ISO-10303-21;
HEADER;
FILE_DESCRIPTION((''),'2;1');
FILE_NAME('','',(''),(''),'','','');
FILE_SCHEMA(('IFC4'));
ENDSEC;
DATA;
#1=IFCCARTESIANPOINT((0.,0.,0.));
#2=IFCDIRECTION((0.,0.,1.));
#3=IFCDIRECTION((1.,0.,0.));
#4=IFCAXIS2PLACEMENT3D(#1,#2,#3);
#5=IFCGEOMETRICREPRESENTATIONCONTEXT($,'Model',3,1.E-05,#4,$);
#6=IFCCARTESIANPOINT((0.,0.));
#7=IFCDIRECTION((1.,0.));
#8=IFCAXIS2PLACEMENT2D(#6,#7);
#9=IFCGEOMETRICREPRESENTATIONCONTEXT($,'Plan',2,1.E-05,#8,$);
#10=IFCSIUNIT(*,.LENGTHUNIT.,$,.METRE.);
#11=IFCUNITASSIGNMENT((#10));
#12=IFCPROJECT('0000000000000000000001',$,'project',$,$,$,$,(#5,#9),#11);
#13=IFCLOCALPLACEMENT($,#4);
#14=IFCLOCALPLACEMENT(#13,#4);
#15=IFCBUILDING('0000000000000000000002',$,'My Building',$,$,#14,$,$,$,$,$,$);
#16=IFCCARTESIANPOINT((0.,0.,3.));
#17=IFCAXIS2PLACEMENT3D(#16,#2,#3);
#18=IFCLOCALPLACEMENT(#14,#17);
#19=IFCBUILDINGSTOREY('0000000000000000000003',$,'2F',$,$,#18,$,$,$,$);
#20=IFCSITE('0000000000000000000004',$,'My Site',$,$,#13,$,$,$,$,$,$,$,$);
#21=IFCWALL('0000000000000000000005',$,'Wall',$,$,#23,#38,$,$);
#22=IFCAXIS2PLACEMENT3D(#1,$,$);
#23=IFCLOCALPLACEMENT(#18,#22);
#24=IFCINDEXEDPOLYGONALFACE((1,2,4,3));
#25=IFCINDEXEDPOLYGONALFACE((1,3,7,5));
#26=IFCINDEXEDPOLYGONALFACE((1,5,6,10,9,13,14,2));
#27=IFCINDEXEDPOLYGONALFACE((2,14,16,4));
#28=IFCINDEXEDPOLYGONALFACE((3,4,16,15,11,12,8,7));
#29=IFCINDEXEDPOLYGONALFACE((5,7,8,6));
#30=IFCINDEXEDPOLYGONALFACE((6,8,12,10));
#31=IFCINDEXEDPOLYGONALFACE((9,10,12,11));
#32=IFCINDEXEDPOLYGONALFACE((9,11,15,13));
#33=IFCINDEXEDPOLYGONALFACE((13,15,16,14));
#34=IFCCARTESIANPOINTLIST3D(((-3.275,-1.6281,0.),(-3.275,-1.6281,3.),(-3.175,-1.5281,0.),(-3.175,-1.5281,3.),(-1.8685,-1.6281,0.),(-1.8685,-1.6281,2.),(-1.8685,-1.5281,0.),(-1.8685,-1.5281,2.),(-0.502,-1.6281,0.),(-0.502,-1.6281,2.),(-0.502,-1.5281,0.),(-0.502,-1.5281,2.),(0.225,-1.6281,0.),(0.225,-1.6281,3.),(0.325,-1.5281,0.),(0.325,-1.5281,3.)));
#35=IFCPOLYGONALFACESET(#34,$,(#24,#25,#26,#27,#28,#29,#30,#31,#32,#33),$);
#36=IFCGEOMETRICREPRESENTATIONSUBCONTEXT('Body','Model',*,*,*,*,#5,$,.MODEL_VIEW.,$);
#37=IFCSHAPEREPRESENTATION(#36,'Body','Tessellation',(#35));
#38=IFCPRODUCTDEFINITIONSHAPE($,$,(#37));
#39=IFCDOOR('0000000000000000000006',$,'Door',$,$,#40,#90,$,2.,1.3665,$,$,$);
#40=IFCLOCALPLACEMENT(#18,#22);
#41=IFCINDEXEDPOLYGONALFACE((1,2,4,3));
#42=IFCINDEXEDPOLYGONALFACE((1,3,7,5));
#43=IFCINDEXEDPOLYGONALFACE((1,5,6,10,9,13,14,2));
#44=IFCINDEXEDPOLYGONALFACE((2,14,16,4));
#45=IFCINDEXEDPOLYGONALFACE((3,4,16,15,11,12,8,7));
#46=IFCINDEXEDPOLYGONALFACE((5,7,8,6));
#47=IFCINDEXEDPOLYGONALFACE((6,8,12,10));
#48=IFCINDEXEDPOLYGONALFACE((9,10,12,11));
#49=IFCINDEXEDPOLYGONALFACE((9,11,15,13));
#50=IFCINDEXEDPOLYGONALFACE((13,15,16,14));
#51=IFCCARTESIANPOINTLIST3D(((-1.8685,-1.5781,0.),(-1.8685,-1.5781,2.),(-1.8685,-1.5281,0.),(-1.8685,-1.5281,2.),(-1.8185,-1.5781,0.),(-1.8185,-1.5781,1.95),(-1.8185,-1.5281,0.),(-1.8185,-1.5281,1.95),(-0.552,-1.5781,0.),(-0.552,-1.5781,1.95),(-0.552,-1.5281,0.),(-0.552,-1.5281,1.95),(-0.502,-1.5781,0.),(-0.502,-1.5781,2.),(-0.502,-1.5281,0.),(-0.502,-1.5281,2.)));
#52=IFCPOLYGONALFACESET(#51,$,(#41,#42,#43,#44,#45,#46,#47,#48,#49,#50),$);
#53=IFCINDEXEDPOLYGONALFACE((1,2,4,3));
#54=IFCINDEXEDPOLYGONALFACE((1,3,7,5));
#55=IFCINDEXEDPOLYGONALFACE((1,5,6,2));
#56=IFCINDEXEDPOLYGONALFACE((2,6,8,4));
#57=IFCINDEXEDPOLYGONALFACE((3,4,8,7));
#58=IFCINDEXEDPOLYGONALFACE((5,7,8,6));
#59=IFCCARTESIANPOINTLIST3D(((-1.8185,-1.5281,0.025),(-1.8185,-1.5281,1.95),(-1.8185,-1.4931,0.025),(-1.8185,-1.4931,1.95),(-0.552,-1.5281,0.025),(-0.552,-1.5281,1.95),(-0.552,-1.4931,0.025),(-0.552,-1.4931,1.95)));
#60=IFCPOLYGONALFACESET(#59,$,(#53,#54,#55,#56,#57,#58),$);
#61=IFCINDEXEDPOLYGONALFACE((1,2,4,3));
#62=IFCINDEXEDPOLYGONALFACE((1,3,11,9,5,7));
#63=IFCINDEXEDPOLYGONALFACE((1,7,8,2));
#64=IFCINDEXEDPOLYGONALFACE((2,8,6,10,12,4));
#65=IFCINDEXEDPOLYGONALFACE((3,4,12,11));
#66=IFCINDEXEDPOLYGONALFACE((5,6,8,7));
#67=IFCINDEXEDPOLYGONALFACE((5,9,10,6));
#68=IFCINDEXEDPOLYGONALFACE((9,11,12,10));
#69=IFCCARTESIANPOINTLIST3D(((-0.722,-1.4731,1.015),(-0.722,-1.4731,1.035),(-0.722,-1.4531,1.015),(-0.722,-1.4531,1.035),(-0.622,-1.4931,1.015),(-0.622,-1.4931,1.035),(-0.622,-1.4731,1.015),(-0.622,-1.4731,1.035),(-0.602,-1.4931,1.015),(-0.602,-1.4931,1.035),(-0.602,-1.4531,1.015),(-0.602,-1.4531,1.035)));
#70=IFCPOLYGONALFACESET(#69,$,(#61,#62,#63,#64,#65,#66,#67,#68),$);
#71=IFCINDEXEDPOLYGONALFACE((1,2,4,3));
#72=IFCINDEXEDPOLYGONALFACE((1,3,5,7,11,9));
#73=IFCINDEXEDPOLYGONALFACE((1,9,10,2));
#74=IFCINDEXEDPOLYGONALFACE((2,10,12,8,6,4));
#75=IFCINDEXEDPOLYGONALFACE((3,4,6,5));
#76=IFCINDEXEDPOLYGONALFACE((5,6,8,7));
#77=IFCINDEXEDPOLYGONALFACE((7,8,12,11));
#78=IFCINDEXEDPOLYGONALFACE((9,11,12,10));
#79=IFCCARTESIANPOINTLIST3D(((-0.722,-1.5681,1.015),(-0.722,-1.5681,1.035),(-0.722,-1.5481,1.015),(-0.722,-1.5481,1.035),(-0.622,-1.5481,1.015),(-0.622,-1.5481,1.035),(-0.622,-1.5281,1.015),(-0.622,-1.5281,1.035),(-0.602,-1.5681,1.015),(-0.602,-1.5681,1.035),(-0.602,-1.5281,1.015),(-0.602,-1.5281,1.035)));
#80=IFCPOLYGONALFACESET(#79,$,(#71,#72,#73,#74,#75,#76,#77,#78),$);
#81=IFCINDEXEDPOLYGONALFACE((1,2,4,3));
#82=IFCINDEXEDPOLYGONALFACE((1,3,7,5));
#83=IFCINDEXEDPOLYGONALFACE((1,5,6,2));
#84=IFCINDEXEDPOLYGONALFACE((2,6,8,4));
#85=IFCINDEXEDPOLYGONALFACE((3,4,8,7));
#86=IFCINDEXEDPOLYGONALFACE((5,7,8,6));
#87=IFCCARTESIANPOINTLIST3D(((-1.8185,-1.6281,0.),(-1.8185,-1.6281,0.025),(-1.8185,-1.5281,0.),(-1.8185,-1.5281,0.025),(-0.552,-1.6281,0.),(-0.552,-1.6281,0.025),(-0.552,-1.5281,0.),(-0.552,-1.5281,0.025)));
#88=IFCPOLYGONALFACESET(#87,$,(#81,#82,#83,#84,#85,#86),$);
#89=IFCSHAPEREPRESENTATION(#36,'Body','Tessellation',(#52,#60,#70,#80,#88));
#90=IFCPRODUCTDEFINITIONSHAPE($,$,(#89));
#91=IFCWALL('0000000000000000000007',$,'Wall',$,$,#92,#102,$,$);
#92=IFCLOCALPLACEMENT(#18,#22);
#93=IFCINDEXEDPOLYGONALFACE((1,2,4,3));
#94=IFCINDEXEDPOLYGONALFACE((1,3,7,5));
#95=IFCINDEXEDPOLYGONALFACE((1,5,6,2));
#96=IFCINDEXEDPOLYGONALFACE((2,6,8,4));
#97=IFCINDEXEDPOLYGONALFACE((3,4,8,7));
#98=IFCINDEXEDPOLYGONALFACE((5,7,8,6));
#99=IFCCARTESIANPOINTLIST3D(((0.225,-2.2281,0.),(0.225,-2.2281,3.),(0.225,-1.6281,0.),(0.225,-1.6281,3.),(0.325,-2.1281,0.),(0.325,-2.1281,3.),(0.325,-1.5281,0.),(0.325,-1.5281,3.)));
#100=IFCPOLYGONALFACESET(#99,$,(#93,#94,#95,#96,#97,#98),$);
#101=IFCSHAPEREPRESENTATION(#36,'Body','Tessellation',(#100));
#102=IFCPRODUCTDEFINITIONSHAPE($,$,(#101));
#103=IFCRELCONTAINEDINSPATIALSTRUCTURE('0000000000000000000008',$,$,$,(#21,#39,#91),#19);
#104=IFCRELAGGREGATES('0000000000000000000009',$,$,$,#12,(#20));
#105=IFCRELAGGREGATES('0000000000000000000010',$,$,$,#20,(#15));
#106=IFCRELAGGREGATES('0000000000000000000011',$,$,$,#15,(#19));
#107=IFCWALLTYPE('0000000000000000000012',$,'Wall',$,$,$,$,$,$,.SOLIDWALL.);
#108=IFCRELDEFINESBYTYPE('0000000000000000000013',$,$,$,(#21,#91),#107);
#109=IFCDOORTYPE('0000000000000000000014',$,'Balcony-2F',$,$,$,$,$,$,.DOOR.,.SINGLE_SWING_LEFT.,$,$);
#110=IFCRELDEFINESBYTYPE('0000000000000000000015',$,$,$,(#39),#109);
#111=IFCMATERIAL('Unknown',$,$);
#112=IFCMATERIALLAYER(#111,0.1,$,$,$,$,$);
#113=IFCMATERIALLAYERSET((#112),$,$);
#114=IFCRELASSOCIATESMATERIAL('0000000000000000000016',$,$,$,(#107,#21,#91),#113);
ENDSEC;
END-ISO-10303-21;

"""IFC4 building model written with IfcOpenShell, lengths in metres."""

from ifc_helpers import new_model, entity, si_unit, frame, origin_with_axes, origin_2d_with_axis, place, context, subcontext, project, spatial, line, indexed_curve, outline, extrude, shape, source, transform, mapped, material, layer, layer_set, layer_usage, type_object, type_shapes, element, fill, save


model = new_model("IFC4")

# Units and contexts
model_context = context("Model", 3, precision=1e-05, world=origin_with_axes())
plan_context = context("Plan", 2, precision=1e-05, world=origin_2d_with_axis())
body_context_1 = subcontext(model_context, "Body", "Model", "MODEL_VIEW")
body_context_2 = subcontext(plan_context, "Body", "Plan", "PLAN_VIEW")
ifc_project = project(units=[si_unit("LENGTHUNIT", "METRE")], contexts=[model_context, plan_context])

# Site, building, storey
site_placement = place(None, origin_with_axes())
site = spatial("IfcSite", under=ifc_project, at=site_placement, Name="My Site")
building_placement = place(site_placement, origin_with_axes())
building = spatial("IfcBuilding", under=site, at=building_placement, Name="My Building")
storey_placement = place(building_placement, frame((0.0, 0.0, 3.0), z_axis=(0.0, 0.0, 1.0), x_axis=(1.0, 0.0, 0.0)))
storey = spatial("IfcBuildingStorey", under=building, at=storey_placement, Name="2F")

# Shared definitions
ifc_material = material(Name="Unknown")

# Wall, opening, door
ifc_layer_1 = layer(ifc_material, 0.1)
ifc_layer_set_1 = layer_set([ifc_layer_1])
ifc_layer_usage_1 = layer_usage(ifc_layer_set_1, "AXIS2", "POSITIVE", 0.0)
wall_type = type_object("IfcWallType", Name="Wall", PredefinedType="SOLIDWALL", material=ifc_layer_set_1)
wall_1_placement = place(storey_placement, frame((-3.275, -1.6281, 0.0), z_axis=(0.0, 0.0, 1.0), x_axis=(1.0, 0.0, 0.0)))
wall_1 = element("IfcWall", 1, at=wall_1_placement, inside=storey, type_object=wall_type, material=ifc_layer_usage_1, Name="Wall", context=body_context_1, shape_type="SweptSolid", body=[
    extrude(outline(indexed_curve([(0.0, 0.0), (0.1, 0.1), (3.6, 0.1), (3.5, 0.0)], segments=[line(1, 2, 3, 4, 1)])), origin_with_axes(), (0.0, 0.0, 1.0), 3.0),
])
shared_shape_1 = source(origin_with_axes(), body_context_1, "Body", "SweptSolid", [
    extrude(outline(indexed_curve([(0.0, 0.0), (1.3665, 0.0), (1.3665, 2.0), (0.0, 2.0)], segments=[line(1, 2, 3, 4, 1)])), frame((0.0, -0.6, 0.0), z_axis=(0.0, -1.0, 0.0), x_axis=(1.0, 0.0, 0.0)), (0.0, 0.0, -1.0), 1.2),
])
opening_1_placement = place(wall_1_placement, frame((2.773, 0.1, 0.0), z_axis=(0.0, 0.0, 1.0), x_axis=(-1.0, 0.0, 0.0)))
opening_1 = element("IfcOpeningElement", 2, at=opening_1_placement, cuts=wall_1, PredefinedType="OPENING", context=body_context_1, shape_type="MappedRepresentation", body=[
    mapped(shared_shape_1, transform((0.0, 0.0, 0.0), x_axis=(1.0, 0.0, 0.0), y_axis=(0.0, 1.0, 0.0), z_axis=(0.0, 0.0, 1.0), scale=1.0)),
])
door_type_1 = type_object("IfcDoorType", Name="Balcony-2F", OperationType="SINGLE_SWING_LEFT", PredefinedType="DOOR")
shared_shape_2 = source(origin_with_axes(), body_context_1, "Body", "SweptSolid", [
    extrude(outline(indexed_curve([(0.0, 0.0), (0.0, 2.0), (1.3665, 2.0), (1.3665, 0.0), (1.3165, 0.0), (1.3165, 1.95), (0.05, 1.95), (0.05, 0.0)], segments=[line(1, 2, 3, 4, 5, 6, 7, 8, 1)])), frame((0.0, 0.0, 0.0), z_axis=(0.0, -1.0, 0.0), x_axis=(1.0, 0.0, 0.0)), (0.0, 0.0, -1.0), 0.05),
    extrude(outline(indexed_curve([(0.0, 0.0), (1.2665, 0.0), (1.2665, 0.035), (0.0, 0.035)], segments=[line(1, 2, 3, 4, 1)])), frame((0.05, -0.035, 0.025), z_axis=(0.0, 0.0, 1.0), x_axis=(1.0, 0.0, 0.0)), (0.0, 0.0, 1.0), 1.925),
    extrude(outline(indexed_curve([(0.0, 0.0), (0.0, -0.04), (0.12, -0.04), (0.12, -0.02), (0.02, -0.02), (0.02, 0.0)], segments=[line(1, 2, 3, 4, 5, 6, 1)])), frame((0.1, -0.035, 1.015), z_axis=(0.0, 0.0, 1.0), x_axis=(1.0, 0.0, 0.0)), (0.0, 0.0, 1.0), 0.02),
    extrude(outline(indexed_curve([(0.0, 0.0), (0.0, 0.04), (0.12, 0.04), (0.12, 0.02), (0.02, 0.02), (0.02, 0.0)], segments=[line(1, 2, 3, 4, 5, 6, 1)])), frame((0.1, 0.0, 1.015), z_axis=(0.0, 0.0, 1.0), x_axis=(1.0, 0.0, 0.0)), (0.0, 0.0, 1.0), 0.02),
    extrude(outline(indexed_curve([(0.0, 0.0), (1.2665, 0.0), (1.2665, 0.1), (0.0, 0.1)], segments=[line(1, 2, 3, 4, 1)])), frame((0.05, 0.0, 0.0), z_axis=(0.0, 0.0, 1.0), x_axis=(1.0, 0.0, 0.0)), (0.0, 0.0, 1.0), 0.025),
])
shared_shape_3 = source(origin_with_axes(), body_context_2, "Body", "Curve2D", [
    entity("IfcIndexedPolyCurve", entity("IfcCartesianPointList2D", [[0.0, 0.0], [0.05, 0.0], [0.05, 0.05], [0.0, 0.05]]), [entity("IfcLineIndex", [1, 2, 3, 4, 1])]),
    entity("IfcIndexedPolyCurve", entity("IfcCartesianPointList2D", [[1.3665, 0.0], [1.3165, 0.0], [1.3165, 0.05], [1.3665, 0.05]]), [entity("IfcLineIndex", [1, 2, 3, 4, 1])]),
    entity("IfcIndexedPolyCurve", entity("IfcCartesianPointList2D", [[1.9498, -0.035], [0.6833, -0.035], [0.6833, 0.0], [1.9498, 0.0]]), [entity("IfcLineIndex", [1, 2, 3, 4, 1])]),
])
type_shapes(door_type_1, [shared_shape_2, shared_shape_3])
door_1_placement = place(opening_1_placement, origin_with_axes())
door_1 = element("IfcDoor", 3, at=door_1_placement, inside=storey, type_object=door_type_1, Name="Door", OverallHeight=2.0, OverallWidth=1.3665, shapes=[
    shape(body_context_1, "Body", "MappedRepresentation", [mapped(shared_shape_2, transform((0.0, 0.0, 0.0), x_axis=(1.0, 0.0, 0.0), y_axis=(0.0, 1.0, 0.0), z_axis=(0.0, 0.0, 1.0), scale=1.0))]),
    shape(body_context_2, "Body", "MappedRepresentation", [mapped(shared_shape_3, transform((0.0, 0.0, 0.0), x_axis=(1.0, 0.0, 0.0), y_axis=(0.0, 1.0, 0.0), z_axis=(0.0, 0.0, 1.0), scale=1.0))]),
])
fill(opening_1, door_1)

# Wall
ifc_layer_usage_2 = layer_usage(ifc_layer_set_1, "AXIS2", "POSITIVE", 0.0)
wall_2_placement = place(storey_placement, frame((0.225, -1.6281, 0.0), z_axis=(0.0, 0.0, 1.0), x_axis=(0.0, -1.0, 0.0)))
element("IfcWall", 4, at=wall_2_placement, inside=storey, type_object=wall_type, material=ifc_layer_usage_2, Name="Wall", context=body_context_1, shape_type="SweptSolid", body=[
    extrude(outline(indexed_curve([(0.0, 0.0), (-0.1, 0.1), (0.5, 0.1), (0.6, 0.0)], segments=[line(1, 2, 3, 4, 1)])), origin_with_axes(), (0.0, 0.0, 1.0), 3.0),
])

save(model, "model.ifc")
